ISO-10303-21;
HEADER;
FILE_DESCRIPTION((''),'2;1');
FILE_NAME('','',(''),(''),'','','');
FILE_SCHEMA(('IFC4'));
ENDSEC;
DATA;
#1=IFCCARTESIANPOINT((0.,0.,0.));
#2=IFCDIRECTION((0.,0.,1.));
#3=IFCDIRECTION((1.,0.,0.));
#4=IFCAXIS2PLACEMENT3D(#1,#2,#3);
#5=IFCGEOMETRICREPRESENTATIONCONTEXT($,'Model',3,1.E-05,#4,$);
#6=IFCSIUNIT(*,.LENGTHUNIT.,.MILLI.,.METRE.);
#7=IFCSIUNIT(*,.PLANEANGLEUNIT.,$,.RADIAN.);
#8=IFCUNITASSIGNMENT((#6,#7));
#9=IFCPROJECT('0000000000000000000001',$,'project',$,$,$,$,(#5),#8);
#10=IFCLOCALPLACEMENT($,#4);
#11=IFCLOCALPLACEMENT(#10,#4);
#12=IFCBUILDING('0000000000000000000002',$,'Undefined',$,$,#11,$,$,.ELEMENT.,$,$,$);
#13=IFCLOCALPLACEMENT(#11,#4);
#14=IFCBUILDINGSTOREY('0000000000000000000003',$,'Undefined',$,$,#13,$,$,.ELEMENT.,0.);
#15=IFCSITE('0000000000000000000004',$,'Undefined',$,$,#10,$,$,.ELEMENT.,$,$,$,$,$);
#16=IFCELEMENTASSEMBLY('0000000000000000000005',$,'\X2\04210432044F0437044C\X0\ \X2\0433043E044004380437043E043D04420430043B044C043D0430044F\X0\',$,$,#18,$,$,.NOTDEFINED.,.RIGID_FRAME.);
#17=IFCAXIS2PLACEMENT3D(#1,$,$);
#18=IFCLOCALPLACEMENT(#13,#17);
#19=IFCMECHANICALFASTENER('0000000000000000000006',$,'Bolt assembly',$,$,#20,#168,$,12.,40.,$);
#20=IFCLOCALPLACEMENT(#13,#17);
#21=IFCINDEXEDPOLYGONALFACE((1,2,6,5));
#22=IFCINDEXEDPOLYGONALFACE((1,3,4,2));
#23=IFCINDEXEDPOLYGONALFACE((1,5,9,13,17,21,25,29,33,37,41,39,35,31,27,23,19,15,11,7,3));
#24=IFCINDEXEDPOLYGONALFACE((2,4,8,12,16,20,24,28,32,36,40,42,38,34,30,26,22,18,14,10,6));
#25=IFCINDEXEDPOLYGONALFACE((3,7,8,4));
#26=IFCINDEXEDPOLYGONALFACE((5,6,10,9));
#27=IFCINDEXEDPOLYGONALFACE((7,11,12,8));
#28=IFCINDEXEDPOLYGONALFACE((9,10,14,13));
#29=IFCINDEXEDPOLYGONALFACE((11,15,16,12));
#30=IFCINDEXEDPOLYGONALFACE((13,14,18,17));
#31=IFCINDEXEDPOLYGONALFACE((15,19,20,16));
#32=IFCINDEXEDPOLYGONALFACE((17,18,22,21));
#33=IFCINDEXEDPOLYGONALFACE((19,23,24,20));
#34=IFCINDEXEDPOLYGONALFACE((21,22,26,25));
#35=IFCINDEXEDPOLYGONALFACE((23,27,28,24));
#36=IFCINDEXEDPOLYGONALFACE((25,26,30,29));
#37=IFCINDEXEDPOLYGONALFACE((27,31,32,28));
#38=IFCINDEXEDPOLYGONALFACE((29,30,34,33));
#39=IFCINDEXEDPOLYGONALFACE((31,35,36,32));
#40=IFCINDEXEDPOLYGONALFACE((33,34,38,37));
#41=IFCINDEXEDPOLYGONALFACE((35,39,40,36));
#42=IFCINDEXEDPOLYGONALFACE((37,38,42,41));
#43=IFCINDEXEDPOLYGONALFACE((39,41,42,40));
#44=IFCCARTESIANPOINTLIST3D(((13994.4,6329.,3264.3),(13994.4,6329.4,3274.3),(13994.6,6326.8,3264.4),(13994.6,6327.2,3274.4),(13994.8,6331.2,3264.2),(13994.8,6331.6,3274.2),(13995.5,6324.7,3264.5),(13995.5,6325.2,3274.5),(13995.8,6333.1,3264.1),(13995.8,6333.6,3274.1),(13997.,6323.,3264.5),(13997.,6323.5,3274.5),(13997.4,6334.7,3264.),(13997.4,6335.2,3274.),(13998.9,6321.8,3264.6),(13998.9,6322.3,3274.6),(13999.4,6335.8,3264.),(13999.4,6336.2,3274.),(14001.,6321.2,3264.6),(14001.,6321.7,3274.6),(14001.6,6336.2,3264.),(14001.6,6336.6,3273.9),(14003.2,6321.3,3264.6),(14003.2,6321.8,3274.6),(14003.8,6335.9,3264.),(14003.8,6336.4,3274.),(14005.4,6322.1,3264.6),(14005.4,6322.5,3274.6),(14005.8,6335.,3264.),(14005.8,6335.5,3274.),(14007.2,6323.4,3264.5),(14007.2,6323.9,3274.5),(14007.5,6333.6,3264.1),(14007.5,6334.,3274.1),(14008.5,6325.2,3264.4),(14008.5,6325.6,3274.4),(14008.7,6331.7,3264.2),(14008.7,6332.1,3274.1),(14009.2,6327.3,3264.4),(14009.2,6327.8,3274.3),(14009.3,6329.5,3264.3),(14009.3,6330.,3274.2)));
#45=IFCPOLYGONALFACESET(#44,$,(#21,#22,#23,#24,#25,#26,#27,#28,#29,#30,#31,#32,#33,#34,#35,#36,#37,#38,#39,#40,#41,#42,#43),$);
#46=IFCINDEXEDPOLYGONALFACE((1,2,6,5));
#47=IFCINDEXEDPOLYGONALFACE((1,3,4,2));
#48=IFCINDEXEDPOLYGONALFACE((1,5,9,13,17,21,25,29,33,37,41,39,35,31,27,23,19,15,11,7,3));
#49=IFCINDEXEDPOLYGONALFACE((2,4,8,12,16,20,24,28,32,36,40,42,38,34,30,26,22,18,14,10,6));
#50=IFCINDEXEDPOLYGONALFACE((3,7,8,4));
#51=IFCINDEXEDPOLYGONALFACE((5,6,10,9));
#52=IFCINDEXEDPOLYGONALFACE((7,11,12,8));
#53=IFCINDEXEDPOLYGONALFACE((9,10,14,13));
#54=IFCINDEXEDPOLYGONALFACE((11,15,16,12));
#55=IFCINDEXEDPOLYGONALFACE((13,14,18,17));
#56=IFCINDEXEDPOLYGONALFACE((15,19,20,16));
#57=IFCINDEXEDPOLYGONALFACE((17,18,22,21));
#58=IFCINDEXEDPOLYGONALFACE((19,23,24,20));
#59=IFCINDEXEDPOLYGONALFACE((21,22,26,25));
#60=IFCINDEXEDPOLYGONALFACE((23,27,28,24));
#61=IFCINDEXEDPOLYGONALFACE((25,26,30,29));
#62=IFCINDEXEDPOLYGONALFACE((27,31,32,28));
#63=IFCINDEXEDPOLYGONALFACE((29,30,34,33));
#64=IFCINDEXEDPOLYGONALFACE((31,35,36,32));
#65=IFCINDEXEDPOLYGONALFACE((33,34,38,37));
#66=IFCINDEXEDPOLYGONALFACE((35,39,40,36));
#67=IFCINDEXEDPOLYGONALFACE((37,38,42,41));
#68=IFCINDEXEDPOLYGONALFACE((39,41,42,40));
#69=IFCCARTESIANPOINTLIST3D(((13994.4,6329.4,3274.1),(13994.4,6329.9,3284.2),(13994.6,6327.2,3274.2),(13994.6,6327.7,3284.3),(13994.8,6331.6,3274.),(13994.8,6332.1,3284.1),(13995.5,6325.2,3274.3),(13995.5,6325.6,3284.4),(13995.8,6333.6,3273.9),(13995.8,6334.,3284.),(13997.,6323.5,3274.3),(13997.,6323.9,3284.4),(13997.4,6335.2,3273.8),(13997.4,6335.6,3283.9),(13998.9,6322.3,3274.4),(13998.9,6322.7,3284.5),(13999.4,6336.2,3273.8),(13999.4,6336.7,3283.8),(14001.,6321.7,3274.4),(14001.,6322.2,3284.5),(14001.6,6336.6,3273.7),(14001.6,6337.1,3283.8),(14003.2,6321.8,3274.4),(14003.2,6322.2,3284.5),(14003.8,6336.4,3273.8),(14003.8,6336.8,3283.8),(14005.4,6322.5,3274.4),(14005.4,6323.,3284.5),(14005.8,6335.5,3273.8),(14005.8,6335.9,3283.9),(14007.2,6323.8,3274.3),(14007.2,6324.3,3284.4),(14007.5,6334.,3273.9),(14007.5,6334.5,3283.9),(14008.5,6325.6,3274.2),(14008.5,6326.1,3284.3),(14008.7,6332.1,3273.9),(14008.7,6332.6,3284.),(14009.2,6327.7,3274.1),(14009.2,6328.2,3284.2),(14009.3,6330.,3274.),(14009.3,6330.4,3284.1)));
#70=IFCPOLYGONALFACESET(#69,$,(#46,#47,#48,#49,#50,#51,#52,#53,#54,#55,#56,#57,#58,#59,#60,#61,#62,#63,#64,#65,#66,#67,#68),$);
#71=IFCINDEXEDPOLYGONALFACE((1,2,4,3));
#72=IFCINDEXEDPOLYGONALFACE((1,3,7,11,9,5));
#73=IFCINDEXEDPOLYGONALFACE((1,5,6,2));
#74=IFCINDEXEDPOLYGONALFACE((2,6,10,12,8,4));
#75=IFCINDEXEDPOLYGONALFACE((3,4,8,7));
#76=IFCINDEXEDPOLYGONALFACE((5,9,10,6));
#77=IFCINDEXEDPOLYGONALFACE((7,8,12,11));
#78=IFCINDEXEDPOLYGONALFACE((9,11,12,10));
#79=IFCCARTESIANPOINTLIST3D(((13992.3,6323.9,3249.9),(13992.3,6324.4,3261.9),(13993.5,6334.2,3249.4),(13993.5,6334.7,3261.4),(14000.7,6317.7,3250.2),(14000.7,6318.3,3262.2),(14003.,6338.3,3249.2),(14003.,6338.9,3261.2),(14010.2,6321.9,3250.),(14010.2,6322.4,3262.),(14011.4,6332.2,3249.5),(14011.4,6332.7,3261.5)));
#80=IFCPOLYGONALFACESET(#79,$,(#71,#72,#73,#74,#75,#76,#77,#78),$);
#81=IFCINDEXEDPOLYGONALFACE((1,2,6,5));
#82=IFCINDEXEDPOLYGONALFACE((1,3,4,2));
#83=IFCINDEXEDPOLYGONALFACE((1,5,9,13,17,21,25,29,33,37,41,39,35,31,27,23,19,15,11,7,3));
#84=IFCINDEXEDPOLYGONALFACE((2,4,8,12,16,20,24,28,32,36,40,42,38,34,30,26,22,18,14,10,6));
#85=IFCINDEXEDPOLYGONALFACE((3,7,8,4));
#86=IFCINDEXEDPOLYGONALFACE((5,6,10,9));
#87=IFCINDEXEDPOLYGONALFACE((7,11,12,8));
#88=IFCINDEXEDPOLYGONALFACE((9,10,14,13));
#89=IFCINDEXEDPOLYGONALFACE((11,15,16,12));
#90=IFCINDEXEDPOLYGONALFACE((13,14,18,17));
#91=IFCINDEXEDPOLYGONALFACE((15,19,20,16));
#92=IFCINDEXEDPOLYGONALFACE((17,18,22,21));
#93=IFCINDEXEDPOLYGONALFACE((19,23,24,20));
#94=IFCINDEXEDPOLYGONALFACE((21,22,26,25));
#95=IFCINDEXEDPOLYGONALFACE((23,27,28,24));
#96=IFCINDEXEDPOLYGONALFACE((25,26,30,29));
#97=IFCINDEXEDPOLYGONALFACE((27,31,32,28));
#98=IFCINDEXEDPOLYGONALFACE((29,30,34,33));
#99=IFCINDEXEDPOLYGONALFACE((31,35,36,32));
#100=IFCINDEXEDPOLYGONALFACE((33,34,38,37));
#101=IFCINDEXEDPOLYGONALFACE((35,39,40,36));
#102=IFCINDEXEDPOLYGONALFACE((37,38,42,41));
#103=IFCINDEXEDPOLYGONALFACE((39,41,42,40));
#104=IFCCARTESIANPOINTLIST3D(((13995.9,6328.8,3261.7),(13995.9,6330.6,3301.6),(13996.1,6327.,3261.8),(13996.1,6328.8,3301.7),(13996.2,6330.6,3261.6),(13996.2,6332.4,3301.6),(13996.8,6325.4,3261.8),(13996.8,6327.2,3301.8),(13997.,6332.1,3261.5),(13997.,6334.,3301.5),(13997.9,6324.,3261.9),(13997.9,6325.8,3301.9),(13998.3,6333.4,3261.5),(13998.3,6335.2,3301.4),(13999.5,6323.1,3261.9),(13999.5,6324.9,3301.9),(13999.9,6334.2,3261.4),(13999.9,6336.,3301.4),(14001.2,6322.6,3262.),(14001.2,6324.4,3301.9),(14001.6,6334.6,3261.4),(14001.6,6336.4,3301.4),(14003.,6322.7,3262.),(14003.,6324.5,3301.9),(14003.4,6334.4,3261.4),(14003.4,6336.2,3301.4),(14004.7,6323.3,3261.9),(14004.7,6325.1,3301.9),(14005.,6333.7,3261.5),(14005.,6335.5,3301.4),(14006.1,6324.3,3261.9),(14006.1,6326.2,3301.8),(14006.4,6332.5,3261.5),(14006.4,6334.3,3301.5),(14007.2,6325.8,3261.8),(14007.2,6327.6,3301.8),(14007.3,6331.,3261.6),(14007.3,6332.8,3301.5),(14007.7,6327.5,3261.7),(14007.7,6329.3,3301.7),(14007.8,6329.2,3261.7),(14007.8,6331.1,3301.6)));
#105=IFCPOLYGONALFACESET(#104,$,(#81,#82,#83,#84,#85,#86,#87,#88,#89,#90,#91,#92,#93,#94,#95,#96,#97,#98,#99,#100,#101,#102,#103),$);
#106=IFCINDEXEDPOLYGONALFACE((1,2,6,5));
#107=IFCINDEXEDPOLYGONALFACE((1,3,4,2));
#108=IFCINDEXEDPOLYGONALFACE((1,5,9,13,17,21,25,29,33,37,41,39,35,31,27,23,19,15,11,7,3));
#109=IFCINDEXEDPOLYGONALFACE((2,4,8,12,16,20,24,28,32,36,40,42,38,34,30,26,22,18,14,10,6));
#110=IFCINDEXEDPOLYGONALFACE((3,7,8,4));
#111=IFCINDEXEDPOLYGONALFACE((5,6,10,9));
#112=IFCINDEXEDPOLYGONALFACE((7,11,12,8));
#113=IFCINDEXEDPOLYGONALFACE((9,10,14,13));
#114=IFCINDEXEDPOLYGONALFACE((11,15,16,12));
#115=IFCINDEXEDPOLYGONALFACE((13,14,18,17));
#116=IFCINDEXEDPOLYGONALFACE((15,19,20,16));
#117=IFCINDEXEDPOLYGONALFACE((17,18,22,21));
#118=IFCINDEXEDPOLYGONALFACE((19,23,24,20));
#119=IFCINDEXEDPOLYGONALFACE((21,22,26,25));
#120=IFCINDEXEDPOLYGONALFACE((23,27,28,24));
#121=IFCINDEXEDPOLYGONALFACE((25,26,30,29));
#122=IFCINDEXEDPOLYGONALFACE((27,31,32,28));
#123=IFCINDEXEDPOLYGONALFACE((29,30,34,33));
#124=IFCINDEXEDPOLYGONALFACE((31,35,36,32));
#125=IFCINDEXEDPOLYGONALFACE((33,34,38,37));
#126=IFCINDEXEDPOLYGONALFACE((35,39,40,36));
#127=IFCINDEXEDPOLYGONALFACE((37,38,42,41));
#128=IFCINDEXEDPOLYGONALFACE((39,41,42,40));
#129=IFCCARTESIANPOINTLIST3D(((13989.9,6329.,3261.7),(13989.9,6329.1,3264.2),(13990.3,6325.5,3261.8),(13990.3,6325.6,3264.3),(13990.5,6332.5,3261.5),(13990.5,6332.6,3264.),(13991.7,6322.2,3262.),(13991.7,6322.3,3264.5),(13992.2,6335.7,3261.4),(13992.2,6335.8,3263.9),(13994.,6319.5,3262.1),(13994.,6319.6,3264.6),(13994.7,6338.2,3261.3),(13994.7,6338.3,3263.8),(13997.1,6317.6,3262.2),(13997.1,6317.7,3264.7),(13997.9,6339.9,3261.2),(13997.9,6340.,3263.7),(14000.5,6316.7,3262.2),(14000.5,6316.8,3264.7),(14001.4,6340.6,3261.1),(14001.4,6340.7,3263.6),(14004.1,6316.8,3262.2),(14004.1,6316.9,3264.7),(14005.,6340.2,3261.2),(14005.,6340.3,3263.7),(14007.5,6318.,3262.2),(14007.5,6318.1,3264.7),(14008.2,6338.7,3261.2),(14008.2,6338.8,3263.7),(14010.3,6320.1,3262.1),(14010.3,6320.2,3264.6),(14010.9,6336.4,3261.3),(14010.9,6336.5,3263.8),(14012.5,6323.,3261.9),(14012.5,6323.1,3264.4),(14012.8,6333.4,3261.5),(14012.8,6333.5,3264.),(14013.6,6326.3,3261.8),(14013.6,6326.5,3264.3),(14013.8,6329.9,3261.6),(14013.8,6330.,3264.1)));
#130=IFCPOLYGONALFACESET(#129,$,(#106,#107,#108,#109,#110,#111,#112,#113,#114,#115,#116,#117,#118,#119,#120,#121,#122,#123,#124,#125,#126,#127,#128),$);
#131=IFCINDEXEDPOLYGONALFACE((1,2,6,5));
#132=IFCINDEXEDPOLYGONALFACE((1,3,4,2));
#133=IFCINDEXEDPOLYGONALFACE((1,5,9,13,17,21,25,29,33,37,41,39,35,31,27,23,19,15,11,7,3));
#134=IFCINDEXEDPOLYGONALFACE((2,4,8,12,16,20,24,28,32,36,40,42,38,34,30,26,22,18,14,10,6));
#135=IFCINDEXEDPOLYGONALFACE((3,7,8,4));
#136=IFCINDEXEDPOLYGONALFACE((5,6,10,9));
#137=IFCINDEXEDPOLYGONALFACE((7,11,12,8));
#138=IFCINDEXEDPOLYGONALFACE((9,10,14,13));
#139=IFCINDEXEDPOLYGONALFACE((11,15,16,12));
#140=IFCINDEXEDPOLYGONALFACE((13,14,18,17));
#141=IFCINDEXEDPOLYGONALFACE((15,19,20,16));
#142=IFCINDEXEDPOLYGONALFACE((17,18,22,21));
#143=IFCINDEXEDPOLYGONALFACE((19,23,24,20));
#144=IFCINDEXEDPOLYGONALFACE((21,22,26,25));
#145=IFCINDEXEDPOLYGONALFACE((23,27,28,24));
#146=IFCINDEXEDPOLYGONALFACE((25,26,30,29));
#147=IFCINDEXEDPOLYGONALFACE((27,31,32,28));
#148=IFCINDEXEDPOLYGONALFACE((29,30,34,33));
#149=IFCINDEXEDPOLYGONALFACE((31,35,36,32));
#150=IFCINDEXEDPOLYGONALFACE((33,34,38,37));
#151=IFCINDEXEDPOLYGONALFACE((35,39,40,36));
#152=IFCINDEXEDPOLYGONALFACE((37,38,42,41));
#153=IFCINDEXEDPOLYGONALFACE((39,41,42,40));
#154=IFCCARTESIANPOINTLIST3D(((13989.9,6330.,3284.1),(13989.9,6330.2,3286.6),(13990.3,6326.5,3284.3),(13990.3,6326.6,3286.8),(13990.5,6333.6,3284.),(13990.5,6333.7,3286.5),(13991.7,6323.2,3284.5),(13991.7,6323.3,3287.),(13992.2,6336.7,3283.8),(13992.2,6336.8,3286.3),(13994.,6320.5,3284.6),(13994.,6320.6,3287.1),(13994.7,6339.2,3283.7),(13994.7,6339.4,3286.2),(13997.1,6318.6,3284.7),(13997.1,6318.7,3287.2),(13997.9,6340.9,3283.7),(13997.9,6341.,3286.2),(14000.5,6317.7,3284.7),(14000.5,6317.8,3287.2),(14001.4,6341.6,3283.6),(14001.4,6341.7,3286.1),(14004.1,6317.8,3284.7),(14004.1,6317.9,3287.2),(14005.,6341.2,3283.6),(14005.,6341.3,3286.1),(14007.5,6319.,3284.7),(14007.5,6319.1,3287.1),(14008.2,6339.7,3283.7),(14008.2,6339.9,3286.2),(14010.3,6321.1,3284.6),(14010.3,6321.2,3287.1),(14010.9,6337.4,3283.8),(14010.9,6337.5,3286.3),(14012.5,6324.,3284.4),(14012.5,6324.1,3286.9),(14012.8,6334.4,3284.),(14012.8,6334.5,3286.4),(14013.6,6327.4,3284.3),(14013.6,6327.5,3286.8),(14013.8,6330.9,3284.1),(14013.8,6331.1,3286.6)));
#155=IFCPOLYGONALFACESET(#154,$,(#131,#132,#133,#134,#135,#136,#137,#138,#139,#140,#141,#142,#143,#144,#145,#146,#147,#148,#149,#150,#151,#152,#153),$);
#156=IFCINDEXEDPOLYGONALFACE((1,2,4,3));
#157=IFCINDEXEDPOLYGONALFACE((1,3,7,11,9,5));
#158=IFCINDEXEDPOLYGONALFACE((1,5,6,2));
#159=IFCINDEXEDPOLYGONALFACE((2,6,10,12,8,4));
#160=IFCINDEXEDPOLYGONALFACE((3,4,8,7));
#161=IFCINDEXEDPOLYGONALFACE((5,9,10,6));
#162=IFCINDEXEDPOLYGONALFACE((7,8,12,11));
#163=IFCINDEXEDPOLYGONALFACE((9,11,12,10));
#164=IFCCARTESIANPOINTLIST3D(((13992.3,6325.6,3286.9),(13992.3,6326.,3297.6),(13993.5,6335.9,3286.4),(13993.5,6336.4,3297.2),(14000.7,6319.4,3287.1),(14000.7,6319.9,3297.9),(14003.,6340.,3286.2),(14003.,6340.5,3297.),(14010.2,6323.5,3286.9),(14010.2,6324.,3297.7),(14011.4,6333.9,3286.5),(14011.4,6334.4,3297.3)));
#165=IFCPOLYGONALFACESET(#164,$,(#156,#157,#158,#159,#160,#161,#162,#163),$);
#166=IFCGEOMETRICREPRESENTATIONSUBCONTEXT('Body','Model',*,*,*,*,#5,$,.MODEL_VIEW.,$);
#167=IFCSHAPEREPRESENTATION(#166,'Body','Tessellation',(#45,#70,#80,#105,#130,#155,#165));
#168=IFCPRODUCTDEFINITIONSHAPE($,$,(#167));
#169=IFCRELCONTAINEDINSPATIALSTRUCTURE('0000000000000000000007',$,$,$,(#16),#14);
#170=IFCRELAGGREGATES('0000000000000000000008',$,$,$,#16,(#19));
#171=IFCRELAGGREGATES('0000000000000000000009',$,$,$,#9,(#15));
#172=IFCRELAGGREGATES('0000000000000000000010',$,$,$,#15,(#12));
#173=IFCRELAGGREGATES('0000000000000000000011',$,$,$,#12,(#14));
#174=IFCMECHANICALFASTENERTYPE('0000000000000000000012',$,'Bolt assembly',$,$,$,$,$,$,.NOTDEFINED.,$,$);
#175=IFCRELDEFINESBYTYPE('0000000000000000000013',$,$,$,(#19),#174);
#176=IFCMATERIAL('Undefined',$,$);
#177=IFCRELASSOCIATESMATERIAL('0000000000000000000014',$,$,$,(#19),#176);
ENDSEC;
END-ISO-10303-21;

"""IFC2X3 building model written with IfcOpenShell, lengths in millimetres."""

from ifc_helpers import new_model, si_unit, frame, origin_with_axes, origin_2d_with_axis, place, context, subcontext, project, spatial, polyline, circle, outline, extrude, source, transform, mapped, material, type_object, element, aggregate, save


model = new_model("IFC2X3")

# Units and contexts
model_context = context("Model", 3, precision=1e-05, world=origin_with_axes())
body_context = subcontext(model_context, "Body", "Model", "MODEL_VIEW")
ifc_project = project(units=[si_unit("LENGTHUNIT", "METRE", prefix="MILLI"), si_unit("PLANEANGLEUNIT", "RADIAN")], contexts=[model_context])

# Site, building, storey
site_placement = place(None, origin_with_axes())
site = spatial("IfcSite", under=ifc_project, at=site_placement, Name="Undefined", CompositionType="ELEMENT")
building_placement = place(site_placement, origin_with_axes())
building = spatial("IfcBuilding", under=site, at=building_placement, Name="Undefined", CompositionType="ELEMENT")
storey_placement = place(building_placement, origin_with_axes())
storey = spatial("IfcBuildingStorey", under=building, at=storey_placement, Name="Undefined", CompositionType="ELEMENT", Elevation=0.0)

# Element assembly
assembly_1_placement = place(storey_placement, origin_with_axes())
assembly_1 = element("IfcElementAssembly", 1, at=assembly_1_placement, inside=storey, Name="Связь горизонтальная", AssemblyPlace="NOTDEFINED", PredefinedType="RIGID_FRAME")

# Mechanical fastener
ifc_material_1 = material(Name="Undefined")
mechanical_fastener_type = type_object("IfcMechanicalFastenerType", Name="Bolt assembly")
shared_shape_1 = source(origin_with_axes(), body_context, "Body", "SweptSolid", [
    extrude(circle(Radius=7.5, at=origin_2d_with_axis()), frame((0.0, 0.1, 0.0), z_axis=(0.0, 1.0, 0.0), x_axis=(1.0, 0.0, 0.0)), (0.0, 0.0, 1.0), 10.0),
    extrude(circle(Radius=7.5, at=origin_2d_with_axis()), frame((0.0, 9.9, 0.0), z_axis=(0.0, 1.0, 0.0), x_axis=(1.0, 0.0, 0.0)), (0.0, 0.0, 1.0), 10.1),
    extrude(outline(polyline([(10.4, 0.0), (5.2, 9.0), (-5.2, 9.0), (-10.4, 0.0), (-5.2, -9.0), (5.2, -9.0), (10.4, 0.0)])), frame((0.0, -14.5, 0.0), z_axis=(0.0, 1.0, 0.0), x_axis=(1.0, 0.0, 0.0)), (0.0, 0.0, 1.0), 12.0),
    extrude(circle(Radius=6.0, at=origin_2d_with_axis()), frame((0.0, -2.5, 0.0), z_axis=(0.0, 1.0, 0.0), x_axis=(1.0, 0.0, 0.0)), (0.0, 0.0, 1.0), 40.0),
    extrude(circle(Radius=12.0, at=origin_2d_with_axis()), frame((0.0, -2.5, 0.0), z_axis=(0.0, 1.0, 0.0), x_axis=(1.0, 0.0, 0.0)), (0.0, 0.0, 1.0), 2.5),
    extrude(circle(Radius=12.0, at=origin_2d_with_axis()), frame((0.0, 20.0, 0.0), z_axis=(0.0, 1.0, 0.0), x_axis=(1.0, 0.0, 0.0)), (0.0, 0.0, 1.0), 2.5),
    extrude(outline(polyline([(10.4, 0.0), (5.2, 9.0), (-5.2, 9.0), (-10.4, 0.0), (-5.2, -9.0), (5.2, -9.0), (10.4, 0.0)])), frame((0.0, 22.5, 0.0), z_axis=(0.0, 1.0, 0.0), x_axis=(1.0, 0.0, 0.0)), (0.0, 0.0, 1.0), 10.8),
])
mechanical_fastener_1_placement = place(assembly_1_placement, frame((14001.9, 6328.7, 3264.2), z_axis=(0.593795, 0.803786, -0.036536), x_axis=(-0.804616, 0.593183, -0.026963)))
mechanical_fastener_1 = element("IfcMechanicalFastener", 2, at=mechanical_fastener_1_placement, type_object=mechanical_fastener_type, material=ifc_material_1, Name="Bolt assembly", NominalDiameter=12.0, NominalLength=40.0, context=body_context, shape_type="MappedRepresentation", body=[
    mapped(shared_shape_1, transform((0.0, 0.0, 0.0))),
])
aggregate(assembly_1, [mechanical_fastener_1])

save(model, "model.ifc")
